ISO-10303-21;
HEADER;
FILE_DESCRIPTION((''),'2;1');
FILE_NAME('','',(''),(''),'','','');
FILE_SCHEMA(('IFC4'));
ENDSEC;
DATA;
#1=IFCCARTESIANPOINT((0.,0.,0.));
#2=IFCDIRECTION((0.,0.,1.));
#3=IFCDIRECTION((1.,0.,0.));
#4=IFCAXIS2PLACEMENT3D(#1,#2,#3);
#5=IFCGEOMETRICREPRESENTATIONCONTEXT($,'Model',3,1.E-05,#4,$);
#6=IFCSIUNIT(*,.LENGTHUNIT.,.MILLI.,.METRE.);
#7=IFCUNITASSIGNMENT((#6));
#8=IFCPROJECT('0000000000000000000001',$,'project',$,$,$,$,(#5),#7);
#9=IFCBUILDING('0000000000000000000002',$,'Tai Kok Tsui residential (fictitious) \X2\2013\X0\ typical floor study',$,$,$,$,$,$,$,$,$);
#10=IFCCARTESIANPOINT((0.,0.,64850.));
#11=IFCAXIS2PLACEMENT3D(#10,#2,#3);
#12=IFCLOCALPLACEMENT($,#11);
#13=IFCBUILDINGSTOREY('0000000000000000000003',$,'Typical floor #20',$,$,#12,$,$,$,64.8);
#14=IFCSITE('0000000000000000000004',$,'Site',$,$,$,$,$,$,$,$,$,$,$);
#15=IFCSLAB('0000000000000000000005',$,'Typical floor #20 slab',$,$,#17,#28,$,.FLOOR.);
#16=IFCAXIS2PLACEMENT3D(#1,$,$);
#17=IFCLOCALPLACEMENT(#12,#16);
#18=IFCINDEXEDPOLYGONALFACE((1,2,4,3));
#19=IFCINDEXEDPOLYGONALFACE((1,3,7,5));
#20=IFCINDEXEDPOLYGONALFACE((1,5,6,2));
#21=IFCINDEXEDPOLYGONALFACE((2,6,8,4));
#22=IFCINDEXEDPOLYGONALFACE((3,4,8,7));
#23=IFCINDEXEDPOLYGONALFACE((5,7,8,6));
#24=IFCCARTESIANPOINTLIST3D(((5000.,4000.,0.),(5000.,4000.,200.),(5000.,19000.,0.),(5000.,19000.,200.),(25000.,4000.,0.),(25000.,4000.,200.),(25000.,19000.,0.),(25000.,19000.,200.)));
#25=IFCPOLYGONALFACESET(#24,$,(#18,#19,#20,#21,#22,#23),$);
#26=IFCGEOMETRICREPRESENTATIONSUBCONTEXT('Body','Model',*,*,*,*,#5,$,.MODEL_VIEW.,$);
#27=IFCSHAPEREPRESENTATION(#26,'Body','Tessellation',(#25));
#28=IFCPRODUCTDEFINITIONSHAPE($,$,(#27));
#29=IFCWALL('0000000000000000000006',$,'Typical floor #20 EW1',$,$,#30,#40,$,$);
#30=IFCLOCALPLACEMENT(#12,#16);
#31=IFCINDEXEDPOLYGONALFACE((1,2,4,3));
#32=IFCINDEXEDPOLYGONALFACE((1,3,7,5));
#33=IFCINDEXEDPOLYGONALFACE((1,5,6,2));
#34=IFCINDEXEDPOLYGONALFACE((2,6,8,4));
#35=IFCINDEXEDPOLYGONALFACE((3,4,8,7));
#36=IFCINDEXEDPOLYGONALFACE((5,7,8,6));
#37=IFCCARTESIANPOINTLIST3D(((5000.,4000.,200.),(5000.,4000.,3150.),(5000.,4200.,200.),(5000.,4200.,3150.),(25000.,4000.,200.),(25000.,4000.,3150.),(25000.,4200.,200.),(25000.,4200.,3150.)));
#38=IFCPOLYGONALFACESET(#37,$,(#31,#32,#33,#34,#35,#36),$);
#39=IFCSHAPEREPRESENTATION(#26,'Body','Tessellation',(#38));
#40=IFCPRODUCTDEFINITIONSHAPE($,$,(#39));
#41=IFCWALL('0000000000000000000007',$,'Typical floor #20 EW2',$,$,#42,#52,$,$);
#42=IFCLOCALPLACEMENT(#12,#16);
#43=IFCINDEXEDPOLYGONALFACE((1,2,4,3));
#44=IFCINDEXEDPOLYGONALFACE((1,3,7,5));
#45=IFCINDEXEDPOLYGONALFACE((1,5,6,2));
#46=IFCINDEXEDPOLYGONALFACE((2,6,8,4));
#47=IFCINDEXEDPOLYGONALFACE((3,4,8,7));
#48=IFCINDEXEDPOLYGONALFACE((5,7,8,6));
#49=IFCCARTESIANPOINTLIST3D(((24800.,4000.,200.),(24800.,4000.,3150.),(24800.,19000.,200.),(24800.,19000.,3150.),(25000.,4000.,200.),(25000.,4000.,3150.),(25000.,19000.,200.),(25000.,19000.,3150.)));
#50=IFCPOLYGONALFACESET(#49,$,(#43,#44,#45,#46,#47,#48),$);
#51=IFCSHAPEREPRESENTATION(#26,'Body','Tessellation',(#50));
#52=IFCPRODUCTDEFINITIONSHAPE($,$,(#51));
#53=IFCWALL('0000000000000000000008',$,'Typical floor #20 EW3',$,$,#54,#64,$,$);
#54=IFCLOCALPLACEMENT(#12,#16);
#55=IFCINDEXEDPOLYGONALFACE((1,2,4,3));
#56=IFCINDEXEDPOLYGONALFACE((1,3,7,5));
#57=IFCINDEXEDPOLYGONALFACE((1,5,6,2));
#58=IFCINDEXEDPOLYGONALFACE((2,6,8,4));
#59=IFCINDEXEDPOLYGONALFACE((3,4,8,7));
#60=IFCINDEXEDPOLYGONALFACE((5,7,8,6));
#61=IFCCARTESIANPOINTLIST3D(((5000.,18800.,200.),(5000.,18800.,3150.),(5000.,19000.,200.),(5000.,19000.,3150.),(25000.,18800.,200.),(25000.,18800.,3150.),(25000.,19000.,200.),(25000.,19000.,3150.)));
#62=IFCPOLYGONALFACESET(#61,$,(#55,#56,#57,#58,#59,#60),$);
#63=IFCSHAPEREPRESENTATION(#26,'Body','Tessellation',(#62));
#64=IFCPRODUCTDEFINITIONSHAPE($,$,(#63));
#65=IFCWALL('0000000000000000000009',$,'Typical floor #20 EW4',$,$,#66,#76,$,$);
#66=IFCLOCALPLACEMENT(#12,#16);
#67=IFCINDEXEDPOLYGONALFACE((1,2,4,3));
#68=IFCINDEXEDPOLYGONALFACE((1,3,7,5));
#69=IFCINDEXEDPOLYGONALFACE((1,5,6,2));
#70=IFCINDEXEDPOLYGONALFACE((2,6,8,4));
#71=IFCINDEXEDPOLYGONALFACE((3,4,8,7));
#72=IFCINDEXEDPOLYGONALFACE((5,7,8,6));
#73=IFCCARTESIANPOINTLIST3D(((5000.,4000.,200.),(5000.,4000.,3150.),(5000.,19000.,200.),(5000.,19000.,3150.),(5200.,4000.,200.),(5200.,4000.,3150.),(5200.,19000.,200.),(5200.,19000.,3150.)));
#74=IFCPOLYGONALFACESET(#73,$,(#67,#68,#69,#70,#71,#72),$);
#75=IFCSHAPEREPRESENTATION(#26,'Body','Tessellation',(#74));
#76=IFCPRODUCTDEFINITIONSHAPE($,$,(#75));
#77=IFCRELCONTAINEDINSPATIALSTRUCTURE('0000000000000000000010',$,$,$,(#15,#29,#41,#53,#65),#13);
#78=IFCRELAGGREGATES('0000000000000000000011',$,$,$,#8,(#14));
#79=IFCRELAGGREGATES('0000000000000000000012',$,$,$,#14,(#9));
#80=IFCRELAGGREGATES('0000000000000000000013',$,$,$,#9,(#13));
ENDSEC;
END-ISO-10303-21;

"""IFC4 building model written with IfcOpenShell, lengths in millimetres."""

from ifc_helpers import new_model, si_unit, frame, origin_with_axes, place, context, subcontext, project, spatial, indexed_curve, outline, extrude, element, save


model = new_model("IFC4")

# Units and contexts
model_context = context("Model", 3, precision=1e-05, world=origin_with_axes())
body_context = subcontext(model_context, "Body", "Model", "MODEL_VIEW")
ifc_project = project(units=[si_unit("LENGTHUNIT", "METRE", prefix="MILLI")], contexts=[model_context])

# Site, building, storey
site = spatial("IfcSite", under=ifc_project, Name="Site")
building = spatial("IfcBuilding", under=site, Name="Tai Kok Tsui residential (fictitious) – typical floor study")
storey_placement = place(None, frame((0.0, 0.0, 64850.0), z_axis=(0.0, 0.0, 1.0), x_axis=(1.0, 0.0, 0.0)))
storey = spatial("IfcBuildingStorey", under=building, at=storey_placement, Name="Typical floor #20", Elevation=64.8)

# Slab
slab_placement = place(storey_placement, origin_with_axes())
element("IfcSlab", 1, at=slab_placement, inside=storey, Name="Typical floor #20 slab", PredefinedType="FLOOR", context=body_context, shape_type="SweptSolid", body=[
    extrude(outline(indexed_curve([(5000.0, 4000.0), (25000.0, 4000.0), (25000.0, 19000.0), (5000.0, 19000.0)])), None, (0.0, 0.0, 1.0), 200.0),
])

# Walls
wall_1_placement = place(storey_placement, frame((5000.0, 4000.0, 200.0), z_axis=(0.0, 0.0, 1.0), x_axis=(1.0, 0.0, 0.0)))
element("IfcWall", 2, at=wall_1_placement, inside=storey, Name="Typical floor #20 EW1", context=body_context, shape_type="SweptSolid", body=[
    extrude(outline(indexed_curve([(0.0, 0.0), (0.0, 200.0), (20000.0, 200.0), (20000.0, 0.0), (0.0, 0.0)], self_intersect=False)), origin_with_axes(), (0.0, 0.0, 1.0), 2950.0),
])
wall_2_placement = place(storey_placement, frame((25000.0, 4000.0, 200.0), z_axis=(0.0, 0.0, 1.0), x_axis=(0.0, 1.0, 0.0)))
element("IfcWall", 3, at=wall_2_placement, inside=storey, Name="Typical floor #20 EW2", context=body_context, shape_type="SweptSolid", body=[
    extrude(outline(indexed_curve([(0.0, 0.0), (0.0, 200.0), (15000.0, 200.0), (15000.0, 0.0), (0.0, 0.0)], self_intersect=False)), origin_with_axes(), (0.0, 0.0, 1.0), 2950.0),
])
wall_3_placement = place(storey_placement, frame((25000.0, 19000.0, 200.0), z_axis=(0.0, 0.0, 1.0), x_axis=(-1.0, 0.0, 0.0)))
element("IfcWall", 4, at=wall_3_placement, inside=storey, Name="Typical floor #20 EW3", context=body_context, shape_type="SweptSolid", body=[
    extrude(outline(indexed_curve([(0.0, 0.0), (0.0, 200.0), (20000.0, 200.0), (20000.0, 0.0), (0.0, 0.0)], self_intersect=False)), origin_with_axes(), (0.0, 0.0, 1.0), 2950.0),
])
wall_4_placement = place(storey_placement, frame((5000.0, 19000.0, 200.0), z_axis=(0.0, 0.0, 1.0), x_axis=(0.0, -1.0, 0.0)))
element("IfcWall", 5, at=wall_4_placement, inside=storey, Name="Typical floor #20 EW4", context=body_context, shape_type="SweptSolid", body=[
    extrude(outline(indexed_curve([(0.0, 0.0), (0.0, 200.0), (15000.0, 200.0), (15000.0, 0.0), (0.0, 0.0)], self_intersect=False)), origin_with_axes(), (0.0, 0.0, 1.0), 2950.0),
])

save(model, "model.ifc")
